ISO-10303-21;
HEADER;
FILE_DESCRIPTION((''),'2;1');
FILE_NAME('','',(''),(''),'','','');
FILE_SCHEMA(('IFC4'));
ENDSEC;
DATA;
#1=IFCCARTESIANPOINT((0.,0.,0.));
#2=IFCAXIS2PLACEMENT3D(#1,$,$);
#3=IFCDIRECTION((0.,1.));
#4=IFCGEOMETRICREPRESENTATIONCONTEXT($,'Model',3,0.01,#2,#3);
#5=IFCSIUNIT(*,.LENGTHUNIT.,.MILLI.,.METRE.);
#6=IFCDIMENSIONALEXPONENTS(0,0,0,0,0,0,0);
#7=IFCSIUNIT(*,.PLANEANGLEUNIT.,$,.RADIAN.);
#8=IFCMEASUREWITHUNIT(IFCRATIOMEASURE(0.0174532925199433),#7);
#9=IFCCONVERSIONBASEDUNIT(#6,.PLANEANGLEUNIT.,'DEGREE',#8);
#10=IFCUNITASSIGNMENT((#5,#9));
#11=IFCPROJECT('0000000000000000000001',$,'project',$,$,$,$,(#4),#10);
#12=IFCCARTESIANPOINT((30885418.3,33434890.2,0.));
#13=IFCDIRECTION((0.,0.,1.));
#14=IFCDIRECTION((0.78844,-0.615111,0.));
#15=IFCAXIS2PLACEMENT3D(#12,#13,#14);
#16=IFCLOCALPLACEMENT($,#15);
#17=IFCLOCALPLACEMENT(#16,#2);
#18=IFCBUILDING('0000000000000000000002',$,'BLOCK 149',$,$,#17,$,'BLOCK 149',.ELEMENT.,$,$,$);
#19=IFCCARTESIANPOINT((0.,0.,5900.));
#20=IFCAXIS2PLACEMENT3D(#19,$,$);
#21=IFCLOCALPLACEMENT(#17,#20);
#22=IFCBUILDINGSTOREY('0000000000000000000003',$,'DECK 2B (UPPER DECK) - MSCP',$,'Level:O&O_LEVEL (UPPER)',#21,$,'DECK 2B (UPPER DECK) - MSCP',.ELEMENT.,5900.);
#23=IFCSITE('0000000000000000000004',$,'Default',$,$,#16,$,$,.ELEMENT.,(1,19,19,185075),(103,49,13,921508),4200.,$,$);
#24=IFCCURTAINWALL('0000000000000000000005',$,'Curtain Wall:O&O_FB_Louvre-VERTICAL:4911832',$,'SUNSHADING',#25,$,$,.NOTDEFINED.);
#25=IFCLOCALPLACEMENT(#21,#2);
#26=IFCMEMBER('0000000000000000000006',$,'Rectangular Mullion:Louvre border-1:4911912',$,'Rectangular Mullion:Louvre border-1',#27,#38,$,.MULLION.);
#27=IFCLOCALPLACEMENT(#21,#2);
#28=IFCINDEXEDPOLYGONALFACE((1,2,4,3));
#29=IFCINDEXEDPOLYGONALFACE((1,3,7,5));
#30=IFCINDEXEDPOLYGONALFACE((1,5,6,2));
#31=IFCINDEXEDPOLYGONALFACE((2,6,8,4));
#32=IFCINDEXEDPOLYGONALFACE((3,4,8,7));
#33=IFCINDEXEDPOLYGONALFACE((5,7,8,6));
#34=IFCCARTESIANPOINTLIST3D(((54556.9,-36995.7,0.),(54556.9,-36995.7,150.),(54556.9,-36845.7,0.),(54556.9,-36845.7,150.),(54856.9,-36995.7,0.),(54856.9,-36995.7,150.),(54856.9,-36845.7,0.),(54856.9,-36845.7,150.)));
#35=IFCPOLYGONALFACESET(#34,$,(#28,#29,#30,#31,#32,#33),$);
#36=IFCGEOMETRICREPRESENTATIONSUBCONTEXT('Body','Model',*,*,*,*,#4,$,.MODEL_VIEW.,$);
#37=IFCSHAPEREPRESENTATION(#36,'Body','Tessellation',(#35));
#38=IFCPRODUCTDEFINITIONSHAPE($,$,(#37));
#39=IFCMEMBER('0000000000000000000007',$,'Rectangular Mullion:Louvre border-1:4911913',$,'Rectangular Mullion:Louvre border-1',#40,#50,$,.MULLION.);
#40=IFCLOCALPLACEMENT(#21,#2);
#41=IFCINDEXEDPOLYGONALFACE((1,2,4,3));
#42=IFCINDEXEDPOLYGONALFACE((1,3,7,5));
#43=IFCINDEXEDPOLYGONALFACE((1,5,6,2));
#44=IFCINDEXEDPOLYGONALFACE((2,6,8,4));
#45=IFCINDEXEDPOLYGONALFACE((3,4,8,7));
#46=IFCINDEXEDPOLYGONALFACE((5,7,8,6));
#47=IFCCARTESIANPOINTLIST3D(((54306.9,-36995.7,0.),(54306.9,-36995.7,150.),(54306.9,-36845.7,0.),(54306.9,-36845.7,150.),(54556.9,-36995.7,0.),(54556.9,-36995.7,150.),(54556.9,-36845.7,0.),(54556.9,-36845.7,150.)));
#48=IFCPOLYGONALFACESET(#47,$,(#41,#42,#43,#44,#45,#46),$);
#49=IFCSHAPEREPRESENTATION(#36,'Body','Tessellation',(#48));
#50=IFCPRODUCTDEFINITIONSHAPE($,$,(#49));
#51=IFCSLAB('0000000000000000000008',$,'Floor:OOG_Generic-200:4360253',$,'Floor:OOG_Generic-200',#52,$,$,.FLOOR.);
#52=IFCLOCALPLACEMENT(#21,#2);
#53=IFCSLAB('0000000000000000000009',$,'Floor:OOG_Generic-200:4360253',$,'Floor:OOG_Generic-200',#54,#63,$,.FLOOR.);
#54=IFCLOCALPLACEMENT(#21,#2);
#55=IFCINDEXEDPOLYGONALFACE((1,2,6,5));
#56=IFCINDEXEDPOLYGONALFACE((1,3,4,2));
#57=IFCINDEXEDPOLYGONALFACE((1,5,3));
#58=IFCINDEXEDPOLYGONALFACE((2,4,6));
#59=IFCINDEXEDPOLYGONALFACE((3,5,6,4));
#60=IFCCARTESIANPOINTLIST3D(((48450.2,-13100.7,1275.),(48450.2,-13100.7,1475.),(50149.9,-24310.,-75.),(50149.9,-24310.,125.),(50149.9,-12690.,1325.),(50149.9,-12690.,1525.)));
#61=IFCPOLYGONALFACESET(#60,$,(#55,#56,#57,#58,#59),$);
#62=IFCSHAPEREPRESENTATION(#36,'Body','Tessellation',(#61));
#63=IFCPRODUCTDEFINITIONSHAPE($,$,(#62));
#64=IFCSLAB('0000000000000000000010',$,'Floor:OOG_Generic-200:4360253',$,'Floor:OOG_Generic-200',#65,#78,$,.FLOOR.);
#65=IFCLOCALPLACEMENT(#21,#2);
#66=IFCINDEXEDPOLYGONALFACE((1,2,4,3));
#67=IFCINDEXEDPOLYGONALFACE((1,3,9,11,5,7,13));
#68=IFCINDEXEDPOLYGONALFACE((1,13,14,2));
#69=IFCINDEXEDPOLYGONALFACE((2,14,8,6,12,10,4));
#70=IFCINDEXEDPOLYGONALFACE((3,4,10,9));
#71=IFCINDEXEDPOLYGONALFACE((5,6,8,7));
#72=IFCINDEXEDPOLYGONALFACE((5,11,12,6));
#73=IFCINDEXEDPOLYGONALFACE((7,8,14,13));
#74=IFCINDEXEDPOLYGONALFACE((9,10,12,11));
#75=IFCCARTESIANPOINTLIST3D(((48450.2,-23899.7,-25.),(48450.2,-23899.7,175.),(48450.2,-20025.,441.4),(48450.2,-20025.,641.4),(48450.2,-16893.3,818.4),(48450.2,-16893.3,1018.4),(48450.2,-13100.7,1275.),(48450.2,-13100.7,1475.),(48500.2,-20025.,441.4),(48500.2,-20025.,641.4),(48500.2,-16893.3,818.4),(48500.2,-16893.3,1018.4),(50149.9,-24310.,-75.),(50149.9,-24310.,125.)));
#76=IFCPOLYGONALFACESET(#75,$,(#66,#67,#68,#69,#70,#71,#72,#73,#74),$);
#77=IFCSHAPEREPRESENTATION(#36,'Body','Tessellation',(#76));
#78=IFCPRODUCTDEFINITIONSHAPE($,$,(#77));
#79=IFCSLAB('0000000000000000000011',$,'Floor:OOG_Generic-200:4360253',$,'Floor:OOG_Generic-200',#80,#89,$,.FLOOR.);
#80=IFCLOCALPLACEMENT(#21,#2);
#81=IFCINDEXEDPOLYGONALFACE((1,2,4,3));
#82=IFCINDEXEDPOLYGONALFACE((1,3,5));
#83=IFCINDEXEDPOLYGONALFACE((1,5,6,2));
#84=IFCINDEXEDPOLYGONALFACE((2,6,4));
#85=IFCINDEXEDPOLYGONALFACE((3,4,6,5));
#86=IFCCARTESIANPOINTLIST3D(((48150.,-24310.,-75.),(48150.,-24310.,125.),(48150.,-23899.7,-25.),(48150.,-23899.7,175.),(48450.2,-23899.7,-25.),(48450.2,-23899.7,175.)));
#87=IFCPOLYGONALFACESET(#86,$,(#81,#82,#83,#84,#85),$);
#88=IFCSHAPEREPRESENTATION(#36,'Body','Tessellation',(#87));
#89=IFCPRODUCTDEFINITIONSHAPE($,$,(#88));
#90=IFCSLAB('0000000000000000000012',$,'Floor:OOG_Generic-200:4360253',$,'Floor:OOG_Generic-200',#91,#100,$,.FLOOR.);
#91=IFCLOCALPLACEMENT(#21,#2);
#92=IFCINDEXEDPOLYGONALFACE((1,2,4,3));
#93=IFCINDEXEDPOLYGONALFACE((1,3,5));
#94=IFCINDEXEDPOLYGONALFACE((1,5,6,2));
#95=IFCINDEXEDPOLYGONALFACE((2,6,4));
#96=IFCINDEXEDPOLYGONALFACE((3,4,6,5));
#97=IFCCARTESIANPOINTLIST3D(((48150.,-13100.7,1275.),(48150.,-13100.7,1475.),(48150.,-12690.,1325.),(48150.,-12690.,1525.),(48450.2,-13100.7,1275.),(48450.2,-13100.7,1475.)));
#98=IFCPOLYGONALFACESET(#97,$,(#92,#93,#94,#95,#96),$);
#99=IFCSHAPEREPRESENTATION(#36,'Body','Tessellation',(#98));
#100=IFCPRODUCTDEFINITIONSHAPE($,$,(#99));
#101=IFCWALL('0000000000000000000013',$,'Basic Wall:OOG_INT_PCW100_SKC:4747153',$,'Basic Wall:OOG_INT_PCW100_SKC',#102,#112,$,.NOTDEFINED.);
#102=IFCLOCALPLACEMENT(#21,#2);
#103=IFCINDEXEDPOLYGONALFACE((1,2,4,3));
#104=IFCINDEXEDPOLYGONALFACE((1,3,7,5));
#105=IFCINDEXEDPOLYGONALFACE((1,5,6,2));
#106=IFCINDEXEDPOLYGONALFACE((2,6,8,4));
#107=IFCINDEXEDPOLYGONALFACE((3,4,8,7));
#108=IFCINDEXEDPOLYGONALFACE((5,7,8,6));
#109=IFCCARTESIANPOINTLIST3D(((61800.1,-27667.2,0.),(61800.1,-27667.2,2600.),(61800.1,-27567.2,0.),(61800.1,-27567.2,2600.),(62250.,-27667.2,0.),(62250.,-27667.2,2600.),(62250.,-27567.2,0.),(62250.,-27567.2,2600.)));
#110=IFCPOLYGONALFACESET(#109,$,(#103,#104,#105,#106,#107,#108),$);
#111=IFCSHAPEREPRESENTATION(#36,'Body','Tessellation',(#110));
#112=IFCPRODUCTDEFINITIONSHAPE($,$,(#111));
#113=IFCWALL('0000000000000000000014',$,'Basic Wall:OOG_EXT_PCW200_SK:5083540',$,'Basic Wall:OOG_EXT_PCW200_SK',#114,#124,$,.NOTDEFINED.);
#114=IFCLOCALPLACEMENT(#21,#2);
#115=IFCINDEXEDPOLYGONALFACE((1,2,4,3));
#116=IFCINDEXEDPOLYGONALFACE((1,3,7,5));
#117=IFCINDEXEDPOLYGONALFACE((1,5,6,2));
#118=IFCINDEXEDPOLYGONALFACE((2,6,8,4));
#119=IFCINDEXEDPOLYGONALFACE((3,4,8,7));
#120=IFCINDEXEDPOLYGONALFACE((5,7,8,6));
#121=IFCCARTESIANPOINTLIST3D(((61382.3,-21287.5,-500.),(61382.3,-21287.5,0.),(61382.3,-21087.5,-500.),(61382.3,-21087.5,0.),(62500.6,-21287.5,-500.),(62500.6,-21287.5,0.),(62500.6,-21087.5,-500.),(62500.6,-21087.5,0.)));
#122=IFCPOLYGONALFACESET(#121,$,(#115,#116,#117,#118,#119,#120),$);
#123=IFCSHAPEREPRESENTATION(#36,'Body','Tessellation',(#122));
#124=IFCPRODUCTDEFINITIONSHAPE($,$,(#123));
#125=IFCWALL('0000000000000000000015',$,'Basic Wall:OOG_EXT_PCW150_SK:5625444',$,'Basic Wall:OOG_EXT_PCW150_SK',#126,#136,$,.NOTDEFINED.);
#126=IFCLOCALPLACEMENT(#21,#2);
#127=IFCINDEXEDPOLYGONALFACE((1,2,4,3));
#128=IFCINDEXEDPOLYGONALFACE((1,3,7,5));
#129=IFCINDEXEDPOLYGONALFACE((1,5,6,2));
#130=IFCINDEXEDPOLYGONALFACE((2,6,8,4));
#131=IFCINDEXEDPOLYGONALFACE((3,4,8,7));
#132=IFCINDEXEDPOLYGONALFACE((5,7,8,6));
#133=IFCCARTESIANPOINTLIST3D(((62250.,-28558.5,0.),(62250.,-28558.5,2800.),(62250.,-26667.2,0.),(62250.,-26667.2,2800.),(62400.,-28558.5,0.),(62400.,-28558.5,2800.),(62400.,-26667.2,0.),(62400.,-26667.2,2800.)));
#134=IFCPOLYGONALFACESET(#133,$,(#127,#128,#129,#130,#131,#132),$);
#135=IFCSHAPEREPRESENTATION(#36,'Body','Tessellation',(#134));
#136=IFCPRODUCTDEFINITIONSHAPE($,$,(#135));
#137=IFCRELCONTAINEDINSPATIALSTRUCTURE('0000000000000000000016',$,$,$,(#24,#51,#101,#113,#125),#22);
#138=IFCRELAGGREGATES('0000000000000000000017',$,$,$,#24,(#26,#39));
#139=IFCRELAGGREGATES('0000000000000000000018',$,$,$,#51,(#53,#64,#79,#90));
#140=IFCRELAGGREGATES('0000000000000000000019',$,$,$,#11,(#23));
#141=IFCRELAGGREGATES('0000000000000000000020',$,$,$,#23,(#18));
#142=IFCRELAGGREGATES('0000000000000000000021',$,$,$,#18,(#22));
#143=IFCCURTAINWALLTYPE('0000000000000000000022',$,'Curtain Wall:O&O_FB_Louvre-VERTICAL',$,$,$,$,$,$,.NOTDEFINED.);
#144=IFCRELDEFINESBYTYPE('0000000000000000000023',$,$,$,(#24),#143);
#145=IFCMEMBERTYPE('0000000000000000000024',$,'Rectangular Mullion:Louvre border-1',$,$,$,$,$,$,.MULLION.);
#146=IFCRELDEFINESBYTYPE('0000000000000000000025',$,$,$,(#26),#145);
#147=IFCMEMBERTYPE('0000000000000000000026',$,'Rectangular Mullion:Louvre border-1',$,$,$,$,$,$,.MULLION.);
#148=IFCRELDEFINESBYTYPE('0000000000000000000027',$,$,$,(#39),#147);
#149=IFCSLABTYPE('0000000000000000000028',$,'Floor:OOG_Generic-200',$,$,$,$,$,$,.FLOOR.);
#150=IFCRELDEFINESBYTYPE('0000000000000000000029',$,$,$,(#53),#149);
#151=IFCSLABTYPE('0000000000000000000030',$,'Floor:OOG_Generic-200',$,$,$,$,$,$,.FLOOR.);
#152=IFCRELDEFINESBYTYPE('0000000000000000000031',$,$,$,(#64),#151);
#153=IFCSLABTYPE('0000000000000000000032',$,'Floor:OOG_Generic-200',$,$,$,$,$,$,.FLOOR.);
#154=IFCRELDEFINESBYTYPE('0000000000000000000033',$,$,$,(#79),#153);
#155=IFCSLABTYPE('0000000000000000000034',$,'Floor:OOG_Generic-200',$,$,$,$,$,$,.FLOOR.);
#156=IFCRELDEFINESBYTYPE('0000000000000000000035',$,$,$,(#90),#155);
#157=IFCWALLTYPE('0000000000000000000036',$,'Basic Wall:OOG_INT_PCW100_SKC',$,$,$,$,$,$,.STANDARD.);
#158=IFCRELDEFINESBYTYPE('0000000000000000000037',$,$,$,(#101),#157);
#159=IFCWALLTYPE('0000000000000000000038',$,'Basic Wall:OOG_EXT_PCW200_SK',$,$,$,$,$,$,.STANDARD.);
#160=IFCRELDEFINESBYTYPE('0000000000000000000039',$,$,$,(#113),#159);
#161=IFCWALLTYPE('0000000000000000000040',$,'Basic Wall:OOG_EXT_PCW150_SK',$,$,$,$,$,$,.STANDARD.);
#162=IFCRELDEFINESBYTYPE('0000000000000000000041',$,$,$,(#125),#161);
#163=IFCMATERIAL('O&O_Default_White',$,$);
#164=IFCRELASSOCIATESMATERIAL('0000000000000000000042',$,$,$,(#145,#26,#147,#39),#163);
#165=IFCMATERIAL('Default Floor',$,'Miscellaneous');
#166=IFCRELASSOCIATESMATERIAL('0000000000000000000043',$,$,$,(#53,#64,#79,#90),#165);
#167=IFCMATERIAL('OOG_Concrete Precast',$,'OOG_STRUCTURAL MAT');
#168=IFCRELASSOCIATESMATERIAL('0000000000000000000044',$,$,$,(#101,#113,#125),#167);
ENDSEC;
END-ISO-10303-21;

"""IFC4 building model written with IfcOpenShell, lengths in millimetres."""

from ifc_helpers import new_model, entity, si_unit, converted_unit, direction, frame, origin, place, context, subcontext, project, spatial, indexed_curve, outline, extrude, source, transform, mapped, material, type_object, type_shapes, element, aggregate, save


model = new_model("IFC4")

# Units and contexts
model_context = context("Model", 3, precision=0.01, world=origin(), true_north=direction((0.0, 1.0)))
body_context = subcontext(model_context, "Body", "Model", "MODEL_VIEW")
ifc_project = project(units=[si_unit("LENGTHUNIT", "METRE", prefix="MILLI"), converted_unit("PLANEANGLEUNIT", "DEGREE", entity("IfcRatioMeasure", 0.0174532925199433), si_unit("PLANEANGLEUNIT", "RADIAN"), dimensions=[0, 0, 0, 0, 0, 0, 0])], contexts=[model_context])

# Site, building, storey
site_placement = place(None, frame((30885418.3, 33434890.2, 0.0), z_axis=(0.0, 0.0, 1.0), x_axis=(0.78844, -0.615111, 0.0)))
site = spatial("IfcSite", under=ifc_project, at=site_placement, Name="Default", CompositionType="ELEMENT", RefLatitude=(1, 19, 19, 185075), RefLongitude=(103, 49, 13, 921508), RefElevation=4200.0)
building_placement = place(site_placement, origin())
building = spatial("IfcBuilding", under=site, at=building_placement, Name="BLOCK 149", LongName="BLOCK 149", CompositionType="ELEMENT")
storey_placement = place(building_placement, frame((0.0, 0.0, 5900.0)))
storey = spatial("IfcBuildingStorey", under=building, at=storey_placement, Name="DECK 2B (UPPER DECK) - MSCP", ObjectType="Level:O&O_LEVEL (UPPER)", LongName="DECK 2B (UPPER DECK) - MSCP", CompositionType="ELEMENT", Elevation=5900.0)

# Curtain wall
curtain_wall_type = type_object("IfcCurtainWallType", Name="Curtain Wall:O&O_FB_Louvre-VERTICAL", PredefinedType="NOTDEFINED")
curtain_wall_1_placement = place(storey_placement, frame((0.0, 0.0, -5900.0)))
curtain_wall_1 = element("IfcCurtainWall", 1, at=curtain_wall_1_placement, inside=storey, type_object=curtain_wall_type, Name="Curtain Wall:O&O_FB_Louvre-VERTICAL:4911832", ObjectType="SUNSHADING", PredefinedType="NOTDEFINED")
ifc_material_1 = material(Name="O&O_Default_White")
placement = place(building_placement, origin())

# Members
member_type_1 = type_object("IfcMemberType", Name="Rectangular Mullion:Louvre border-1", PredefinedType="MULLION", material=ifc_material_1)
shared_shape_1 = source(origin(), body_context, "Body", "SweptSolid", [
    extrude(outline(indexed_curve([(-75.0, -75.0), (75.0, -75.0), (75.0, 75.0), (-75.0, 75.0), (-75.0, -75.0)], self_intersect=False)), frame((-75.0, 0.0, -300.0), z_axis=(0.0, 0.0, 1.0), x_axis=(0.0, -1.0, 0.0)), (0.0, 0.0, 1.0), 300.0),
])
type_shapes(member_type_1, [shared_shape_1])
member_1_placement = place(placement, frame((54856.9, -36920.7, 5900.0), z_axis=(1.0, 0.0, 0.0), x_axis=(0.0, 0.0, -1.0)))
member_1 = element("IfcMember", 2, at=member_1_placement, type_object=member_type_1, material=ifc_material_1, Name="Rectangular Mullion:Louvre border-1:4911912", ObjectType="Rectangular Mullion:Louvre border-1", PredefinedType="MULLION", context=body_context, shape_type="MappedRepresentation", body=[
    mapped(shared_shape_1, transform((0.0, 0.0, 0.0), scale=1.0)),
])
member_type_2 = type_object("IfcMemberType", Name="Rectangular Mullion:Louvre border-1", PredefinedType="MULLION", material=ifc_material_1)
shared_shape_2 = source(origin(), body_context, "Body", "SweptSolid", [
    extrude(outline(indexed_curve([(-75.0, -75.0), (75.0, -75.0), (75.0, 75.0), (-75.0, 75.0), (-75.0, -75.0)], self_intersect=False)), frame((-75.0, 0.0, -250.0), z_axis=(0.0, 0.0, 1.0), x_axis=(0.0, -1.0, 0.0)), (0.0, 0.0, 1.0), 250.0),
])
type_shapes(member_type_2, [shared_shape_2])
member_2_placement = place(placement, frame((54556.9, -36920.7, 5900.0), z_axis=(1.0, 0.0, 0.0), x_axis=(0.0, 0.0, -1.0)))
member_2 = element("IfcMember", 3, at=member_2_placement, type_object=member_type_2, material=ifc_material_1, Name="Rectangular Mullion:Louvre border-1:4911913", ObjectType="Rectangular Mullion:Louvre border-1", PredefinedType="MULLION", context=body_context, shape_type="MappedRepresentation", body=[
    mapped(shared_shape_2, transform((0.0, 0.0, 0.0), scale=1.0)),
])
aggregate(curtain_wall_1, [member_1, member_2])

# Slabs
slab_1_placement = place(storey_placement, frame((48150.0, -24310.0, -75.0)))
slab_1 = element("IfcSlab", 4, at=slab_1_placement, inside=storey, Name="Floor:OOG_Generic-200:4360253", ObjectType="Floor:OOG_Generic-200", PredefinedType="FLOOR")
ifc_material_2 = material(Name="Default Floor", Category="Miscellaneous")
slab_type_1 = type_object("IfcSlabType", Name="Floor:OOG_Generic-200", PredefinedType="FLOOR")
slab_2_placement = place(slab_1_placement, origin())
slab_2 = element("IfcSlab", 5, at=slab_2_placement, type_object=slab_type_1, material=ifc_material_2, Name="Floor:OOG_Generic-200:4360253", ObjectType="Floor:OOG_Generic-200", PredefinedType="FLOOR", context=body_context, shape_type="SweptSolid", body=[
    extrude(outline(indexed_curve([(849.9, -5852.0), (849.9, 5852.0), (-849.9, 5438.2), (849.9, -5852.0)], self_intersect=False)), frame((1150.0, 5810.0, 899.7), z_axis=(-0.0003, -0.119617, 0.99282), x_axis=(1.0, -0.000036, 0.000297)), (-0.000297, -0.119617, -0.99282), 200.0),
])
slab_type_2 = type_object("IfcSlabType", Name="Floor:OOG_Generic-200", PredefinedType="FLOOR")
slab_3_placement = place(slab_1_placement, origin())
slab_3 = element("IfcSlab", 6, at=slab_3_placement, type_object=slab_type_2, material=ifc_material_2, Name="Floor:OOG_Generic-200:4360253", ObjectType="Floor:OOG_Generic-200", PredefinedType="FLOOR", context=body_context, shape_type="SweptSolid", body=[
    extrude(outline(indexed_curve([(849.9, -5645.1), (-849.9, 5645.1), (-849.9, 1825.2), (-799.9, 1825.2), (-799.9, -1329.1), (-849.9, -1329.1), (-849.9, -5231.8), (849.9, -5645.1)], self_intersect=False)), frame((1150.0, 5604.6, 875.0), z_axis=(0.000356, -0.119519, 0.992832), x_axis=(1.0, 0.000043, -0.000353)), (0.000353, -0.119519, -0.992832), 200.0),
])
slab_type_3 = type_object("IfcSlabType", Name="Floor:OOG_Generic-200", PredefinedType="FLOOR")
slab_4_placement = place(slab_1_placement, origin())
slab_4 = element("IfcSlab", 7, at=slab_4_placement, type_object=slab_type_3, material=ifc_material_2, Name="Floor:OOG_Generic-200:4360253", ObjectType="Floor:OOG_Generic-200", PredefinedType="FLOOR", context=body_context, shape_type="SweptSolid", body=[
    extrude(outline(indexed_curve([(-150.1, 206.7), (-150.1, -206.7), (150.1, 206.7), (-150.1, 206.7)], self_intersect=False)), frame((150.1, 205.1, 225.0), z_axis=(0.0, -0.120972, 0.992656), x_axis=(1.0, 0.0, 0.0)), (0.0, -0.120972, -0.992656), 200.0),
])
slab_type_4 = type_object("IfcSlabType", Name="Floor:OOG_Generic-200", PredefinedType="FLOOR")
slab_5_placement = place(slab_1_placement, origin())
slab_5 = element("IfcSlab", 8, at=slab_5_placement, type_object=slab_type_4, material=ifc_material_2, Name="Floor:OOG_Generic-200:4360253", ObjectType="Floor:OOG_Generic-200", PredefinedType="FLOOR", context=body_context, shape_type="SweptSolid", body=[
    extrude(outline(indexed_curve([(-150.1, -206.9), (150.1, -206.9), (-150.1, 206.9), (-150.1, -206.9)], self_intersect=False)), frame((150.1, 11414.6, 1575.0), z_axis=(0.0, -0.120838, 0.992672), x_axis=(1.0, 0.0, 0.0)), (0.0, -0.120838, -0.992672), 200.0),
])
aggregate(slab_1, [slab_2, slab_3, slab_4, slab_5])

# Walls
ifc_material_3 = material(Name="OOG_Concrete Precast", Category="OOG_STRUCTURAL MAT")
wall_type_1 = type_object("IfcWallType", Name="Basic Wall:OOG_INT_PCW100_SKC", PredefinedType="STANDARD")
wall_1_placement = place(storey_placement, frame((61800.1, -27617.2, 0.0)))
element("IfcWall", 9, at=wall_1_placement, inside=storey, type_object=wall_type_1, material=ifc_material_3, Name="Basic Wall:OOG_INT_PCW100_SKC:4747153", ObjectType="Basic Wall:OOG_INT_PCW100_SKC", PredefinedType="NOTDEFINED", context=body_context, shape_type="SweptSolid", body=[
    extrude(outline(indexed_curve([(449.9, 50.0), (0.0, 50.0), (0.0, -50.0), (449.9, -50.0), (449.9, 50.0)], self_intersect=False)), origin(), (0.0, 0.0, 1.0), 2600.0),
])
wall_type_2 = type_object("IfcWallType", Name="Basic Wall:OOG_EXT_PCW200_SK", PredefinedType="STANDARD")
wall_2_placement = place(storey_placement, frame((61382.3, -21187.5, -500.0)))
element("IfcWall", 10, at=wall_2_placement, inside=storey, type_object=wall_type_2, material=ifc_material_3, Name="Basic Wall:OOG_EXT_PCW200_SK:5083540", ObjectType="Basic Wall:OOG_EXT_PCW200_SK", PredefinedType="NOTDEFINED", context=body_context, shape_type="SweptSolid", body=[
    extrude(outline(indexed_curve([(1118.3, 100.0), (0.0, 100.0), (0.0, -100.0), (1118.3, -100.0), (1118.3, 100.0)], self_intersect=False)), origin(), (0.0, 0.0, 1.0), 500.0),
])
wall_type_3 = type_object("IfcWallType", Name="Basic Wall:OOG_EXT_PCW150_SK", PredefinedType="STANDARD")
wall_3_placement = place(storey_placement, frame((62325.0, -26667.2, 0.0), z_axis=(0.0, 0.0, 1.0), x_axis=(0.000003, -1.0, 0.0)))
element("IfcWall", 11, at=wall_3_placement, inside=storey, type_object=wall_type_3, material=ifc_material_3, Name="Basic Wall:OOG_EXT_PCW150_SK:5625444", ObjectType="Basic Wall:OOG_EXT_PCW150_SK", PredefinedType="NOTDEFINED", context=body_context, shape_type="SweptSolid", body=[
    extrude(outline(indexed_curve([(1891.3, 75.0), (0.0, 75.0), (0.0, -75.0), (1891.3, -75.0), (1891.3, 75.0)], self_intersect=False)), origin(), (0.0, 0.0, 1.0), 2800.0),
])

save(model, "model.ifc")
